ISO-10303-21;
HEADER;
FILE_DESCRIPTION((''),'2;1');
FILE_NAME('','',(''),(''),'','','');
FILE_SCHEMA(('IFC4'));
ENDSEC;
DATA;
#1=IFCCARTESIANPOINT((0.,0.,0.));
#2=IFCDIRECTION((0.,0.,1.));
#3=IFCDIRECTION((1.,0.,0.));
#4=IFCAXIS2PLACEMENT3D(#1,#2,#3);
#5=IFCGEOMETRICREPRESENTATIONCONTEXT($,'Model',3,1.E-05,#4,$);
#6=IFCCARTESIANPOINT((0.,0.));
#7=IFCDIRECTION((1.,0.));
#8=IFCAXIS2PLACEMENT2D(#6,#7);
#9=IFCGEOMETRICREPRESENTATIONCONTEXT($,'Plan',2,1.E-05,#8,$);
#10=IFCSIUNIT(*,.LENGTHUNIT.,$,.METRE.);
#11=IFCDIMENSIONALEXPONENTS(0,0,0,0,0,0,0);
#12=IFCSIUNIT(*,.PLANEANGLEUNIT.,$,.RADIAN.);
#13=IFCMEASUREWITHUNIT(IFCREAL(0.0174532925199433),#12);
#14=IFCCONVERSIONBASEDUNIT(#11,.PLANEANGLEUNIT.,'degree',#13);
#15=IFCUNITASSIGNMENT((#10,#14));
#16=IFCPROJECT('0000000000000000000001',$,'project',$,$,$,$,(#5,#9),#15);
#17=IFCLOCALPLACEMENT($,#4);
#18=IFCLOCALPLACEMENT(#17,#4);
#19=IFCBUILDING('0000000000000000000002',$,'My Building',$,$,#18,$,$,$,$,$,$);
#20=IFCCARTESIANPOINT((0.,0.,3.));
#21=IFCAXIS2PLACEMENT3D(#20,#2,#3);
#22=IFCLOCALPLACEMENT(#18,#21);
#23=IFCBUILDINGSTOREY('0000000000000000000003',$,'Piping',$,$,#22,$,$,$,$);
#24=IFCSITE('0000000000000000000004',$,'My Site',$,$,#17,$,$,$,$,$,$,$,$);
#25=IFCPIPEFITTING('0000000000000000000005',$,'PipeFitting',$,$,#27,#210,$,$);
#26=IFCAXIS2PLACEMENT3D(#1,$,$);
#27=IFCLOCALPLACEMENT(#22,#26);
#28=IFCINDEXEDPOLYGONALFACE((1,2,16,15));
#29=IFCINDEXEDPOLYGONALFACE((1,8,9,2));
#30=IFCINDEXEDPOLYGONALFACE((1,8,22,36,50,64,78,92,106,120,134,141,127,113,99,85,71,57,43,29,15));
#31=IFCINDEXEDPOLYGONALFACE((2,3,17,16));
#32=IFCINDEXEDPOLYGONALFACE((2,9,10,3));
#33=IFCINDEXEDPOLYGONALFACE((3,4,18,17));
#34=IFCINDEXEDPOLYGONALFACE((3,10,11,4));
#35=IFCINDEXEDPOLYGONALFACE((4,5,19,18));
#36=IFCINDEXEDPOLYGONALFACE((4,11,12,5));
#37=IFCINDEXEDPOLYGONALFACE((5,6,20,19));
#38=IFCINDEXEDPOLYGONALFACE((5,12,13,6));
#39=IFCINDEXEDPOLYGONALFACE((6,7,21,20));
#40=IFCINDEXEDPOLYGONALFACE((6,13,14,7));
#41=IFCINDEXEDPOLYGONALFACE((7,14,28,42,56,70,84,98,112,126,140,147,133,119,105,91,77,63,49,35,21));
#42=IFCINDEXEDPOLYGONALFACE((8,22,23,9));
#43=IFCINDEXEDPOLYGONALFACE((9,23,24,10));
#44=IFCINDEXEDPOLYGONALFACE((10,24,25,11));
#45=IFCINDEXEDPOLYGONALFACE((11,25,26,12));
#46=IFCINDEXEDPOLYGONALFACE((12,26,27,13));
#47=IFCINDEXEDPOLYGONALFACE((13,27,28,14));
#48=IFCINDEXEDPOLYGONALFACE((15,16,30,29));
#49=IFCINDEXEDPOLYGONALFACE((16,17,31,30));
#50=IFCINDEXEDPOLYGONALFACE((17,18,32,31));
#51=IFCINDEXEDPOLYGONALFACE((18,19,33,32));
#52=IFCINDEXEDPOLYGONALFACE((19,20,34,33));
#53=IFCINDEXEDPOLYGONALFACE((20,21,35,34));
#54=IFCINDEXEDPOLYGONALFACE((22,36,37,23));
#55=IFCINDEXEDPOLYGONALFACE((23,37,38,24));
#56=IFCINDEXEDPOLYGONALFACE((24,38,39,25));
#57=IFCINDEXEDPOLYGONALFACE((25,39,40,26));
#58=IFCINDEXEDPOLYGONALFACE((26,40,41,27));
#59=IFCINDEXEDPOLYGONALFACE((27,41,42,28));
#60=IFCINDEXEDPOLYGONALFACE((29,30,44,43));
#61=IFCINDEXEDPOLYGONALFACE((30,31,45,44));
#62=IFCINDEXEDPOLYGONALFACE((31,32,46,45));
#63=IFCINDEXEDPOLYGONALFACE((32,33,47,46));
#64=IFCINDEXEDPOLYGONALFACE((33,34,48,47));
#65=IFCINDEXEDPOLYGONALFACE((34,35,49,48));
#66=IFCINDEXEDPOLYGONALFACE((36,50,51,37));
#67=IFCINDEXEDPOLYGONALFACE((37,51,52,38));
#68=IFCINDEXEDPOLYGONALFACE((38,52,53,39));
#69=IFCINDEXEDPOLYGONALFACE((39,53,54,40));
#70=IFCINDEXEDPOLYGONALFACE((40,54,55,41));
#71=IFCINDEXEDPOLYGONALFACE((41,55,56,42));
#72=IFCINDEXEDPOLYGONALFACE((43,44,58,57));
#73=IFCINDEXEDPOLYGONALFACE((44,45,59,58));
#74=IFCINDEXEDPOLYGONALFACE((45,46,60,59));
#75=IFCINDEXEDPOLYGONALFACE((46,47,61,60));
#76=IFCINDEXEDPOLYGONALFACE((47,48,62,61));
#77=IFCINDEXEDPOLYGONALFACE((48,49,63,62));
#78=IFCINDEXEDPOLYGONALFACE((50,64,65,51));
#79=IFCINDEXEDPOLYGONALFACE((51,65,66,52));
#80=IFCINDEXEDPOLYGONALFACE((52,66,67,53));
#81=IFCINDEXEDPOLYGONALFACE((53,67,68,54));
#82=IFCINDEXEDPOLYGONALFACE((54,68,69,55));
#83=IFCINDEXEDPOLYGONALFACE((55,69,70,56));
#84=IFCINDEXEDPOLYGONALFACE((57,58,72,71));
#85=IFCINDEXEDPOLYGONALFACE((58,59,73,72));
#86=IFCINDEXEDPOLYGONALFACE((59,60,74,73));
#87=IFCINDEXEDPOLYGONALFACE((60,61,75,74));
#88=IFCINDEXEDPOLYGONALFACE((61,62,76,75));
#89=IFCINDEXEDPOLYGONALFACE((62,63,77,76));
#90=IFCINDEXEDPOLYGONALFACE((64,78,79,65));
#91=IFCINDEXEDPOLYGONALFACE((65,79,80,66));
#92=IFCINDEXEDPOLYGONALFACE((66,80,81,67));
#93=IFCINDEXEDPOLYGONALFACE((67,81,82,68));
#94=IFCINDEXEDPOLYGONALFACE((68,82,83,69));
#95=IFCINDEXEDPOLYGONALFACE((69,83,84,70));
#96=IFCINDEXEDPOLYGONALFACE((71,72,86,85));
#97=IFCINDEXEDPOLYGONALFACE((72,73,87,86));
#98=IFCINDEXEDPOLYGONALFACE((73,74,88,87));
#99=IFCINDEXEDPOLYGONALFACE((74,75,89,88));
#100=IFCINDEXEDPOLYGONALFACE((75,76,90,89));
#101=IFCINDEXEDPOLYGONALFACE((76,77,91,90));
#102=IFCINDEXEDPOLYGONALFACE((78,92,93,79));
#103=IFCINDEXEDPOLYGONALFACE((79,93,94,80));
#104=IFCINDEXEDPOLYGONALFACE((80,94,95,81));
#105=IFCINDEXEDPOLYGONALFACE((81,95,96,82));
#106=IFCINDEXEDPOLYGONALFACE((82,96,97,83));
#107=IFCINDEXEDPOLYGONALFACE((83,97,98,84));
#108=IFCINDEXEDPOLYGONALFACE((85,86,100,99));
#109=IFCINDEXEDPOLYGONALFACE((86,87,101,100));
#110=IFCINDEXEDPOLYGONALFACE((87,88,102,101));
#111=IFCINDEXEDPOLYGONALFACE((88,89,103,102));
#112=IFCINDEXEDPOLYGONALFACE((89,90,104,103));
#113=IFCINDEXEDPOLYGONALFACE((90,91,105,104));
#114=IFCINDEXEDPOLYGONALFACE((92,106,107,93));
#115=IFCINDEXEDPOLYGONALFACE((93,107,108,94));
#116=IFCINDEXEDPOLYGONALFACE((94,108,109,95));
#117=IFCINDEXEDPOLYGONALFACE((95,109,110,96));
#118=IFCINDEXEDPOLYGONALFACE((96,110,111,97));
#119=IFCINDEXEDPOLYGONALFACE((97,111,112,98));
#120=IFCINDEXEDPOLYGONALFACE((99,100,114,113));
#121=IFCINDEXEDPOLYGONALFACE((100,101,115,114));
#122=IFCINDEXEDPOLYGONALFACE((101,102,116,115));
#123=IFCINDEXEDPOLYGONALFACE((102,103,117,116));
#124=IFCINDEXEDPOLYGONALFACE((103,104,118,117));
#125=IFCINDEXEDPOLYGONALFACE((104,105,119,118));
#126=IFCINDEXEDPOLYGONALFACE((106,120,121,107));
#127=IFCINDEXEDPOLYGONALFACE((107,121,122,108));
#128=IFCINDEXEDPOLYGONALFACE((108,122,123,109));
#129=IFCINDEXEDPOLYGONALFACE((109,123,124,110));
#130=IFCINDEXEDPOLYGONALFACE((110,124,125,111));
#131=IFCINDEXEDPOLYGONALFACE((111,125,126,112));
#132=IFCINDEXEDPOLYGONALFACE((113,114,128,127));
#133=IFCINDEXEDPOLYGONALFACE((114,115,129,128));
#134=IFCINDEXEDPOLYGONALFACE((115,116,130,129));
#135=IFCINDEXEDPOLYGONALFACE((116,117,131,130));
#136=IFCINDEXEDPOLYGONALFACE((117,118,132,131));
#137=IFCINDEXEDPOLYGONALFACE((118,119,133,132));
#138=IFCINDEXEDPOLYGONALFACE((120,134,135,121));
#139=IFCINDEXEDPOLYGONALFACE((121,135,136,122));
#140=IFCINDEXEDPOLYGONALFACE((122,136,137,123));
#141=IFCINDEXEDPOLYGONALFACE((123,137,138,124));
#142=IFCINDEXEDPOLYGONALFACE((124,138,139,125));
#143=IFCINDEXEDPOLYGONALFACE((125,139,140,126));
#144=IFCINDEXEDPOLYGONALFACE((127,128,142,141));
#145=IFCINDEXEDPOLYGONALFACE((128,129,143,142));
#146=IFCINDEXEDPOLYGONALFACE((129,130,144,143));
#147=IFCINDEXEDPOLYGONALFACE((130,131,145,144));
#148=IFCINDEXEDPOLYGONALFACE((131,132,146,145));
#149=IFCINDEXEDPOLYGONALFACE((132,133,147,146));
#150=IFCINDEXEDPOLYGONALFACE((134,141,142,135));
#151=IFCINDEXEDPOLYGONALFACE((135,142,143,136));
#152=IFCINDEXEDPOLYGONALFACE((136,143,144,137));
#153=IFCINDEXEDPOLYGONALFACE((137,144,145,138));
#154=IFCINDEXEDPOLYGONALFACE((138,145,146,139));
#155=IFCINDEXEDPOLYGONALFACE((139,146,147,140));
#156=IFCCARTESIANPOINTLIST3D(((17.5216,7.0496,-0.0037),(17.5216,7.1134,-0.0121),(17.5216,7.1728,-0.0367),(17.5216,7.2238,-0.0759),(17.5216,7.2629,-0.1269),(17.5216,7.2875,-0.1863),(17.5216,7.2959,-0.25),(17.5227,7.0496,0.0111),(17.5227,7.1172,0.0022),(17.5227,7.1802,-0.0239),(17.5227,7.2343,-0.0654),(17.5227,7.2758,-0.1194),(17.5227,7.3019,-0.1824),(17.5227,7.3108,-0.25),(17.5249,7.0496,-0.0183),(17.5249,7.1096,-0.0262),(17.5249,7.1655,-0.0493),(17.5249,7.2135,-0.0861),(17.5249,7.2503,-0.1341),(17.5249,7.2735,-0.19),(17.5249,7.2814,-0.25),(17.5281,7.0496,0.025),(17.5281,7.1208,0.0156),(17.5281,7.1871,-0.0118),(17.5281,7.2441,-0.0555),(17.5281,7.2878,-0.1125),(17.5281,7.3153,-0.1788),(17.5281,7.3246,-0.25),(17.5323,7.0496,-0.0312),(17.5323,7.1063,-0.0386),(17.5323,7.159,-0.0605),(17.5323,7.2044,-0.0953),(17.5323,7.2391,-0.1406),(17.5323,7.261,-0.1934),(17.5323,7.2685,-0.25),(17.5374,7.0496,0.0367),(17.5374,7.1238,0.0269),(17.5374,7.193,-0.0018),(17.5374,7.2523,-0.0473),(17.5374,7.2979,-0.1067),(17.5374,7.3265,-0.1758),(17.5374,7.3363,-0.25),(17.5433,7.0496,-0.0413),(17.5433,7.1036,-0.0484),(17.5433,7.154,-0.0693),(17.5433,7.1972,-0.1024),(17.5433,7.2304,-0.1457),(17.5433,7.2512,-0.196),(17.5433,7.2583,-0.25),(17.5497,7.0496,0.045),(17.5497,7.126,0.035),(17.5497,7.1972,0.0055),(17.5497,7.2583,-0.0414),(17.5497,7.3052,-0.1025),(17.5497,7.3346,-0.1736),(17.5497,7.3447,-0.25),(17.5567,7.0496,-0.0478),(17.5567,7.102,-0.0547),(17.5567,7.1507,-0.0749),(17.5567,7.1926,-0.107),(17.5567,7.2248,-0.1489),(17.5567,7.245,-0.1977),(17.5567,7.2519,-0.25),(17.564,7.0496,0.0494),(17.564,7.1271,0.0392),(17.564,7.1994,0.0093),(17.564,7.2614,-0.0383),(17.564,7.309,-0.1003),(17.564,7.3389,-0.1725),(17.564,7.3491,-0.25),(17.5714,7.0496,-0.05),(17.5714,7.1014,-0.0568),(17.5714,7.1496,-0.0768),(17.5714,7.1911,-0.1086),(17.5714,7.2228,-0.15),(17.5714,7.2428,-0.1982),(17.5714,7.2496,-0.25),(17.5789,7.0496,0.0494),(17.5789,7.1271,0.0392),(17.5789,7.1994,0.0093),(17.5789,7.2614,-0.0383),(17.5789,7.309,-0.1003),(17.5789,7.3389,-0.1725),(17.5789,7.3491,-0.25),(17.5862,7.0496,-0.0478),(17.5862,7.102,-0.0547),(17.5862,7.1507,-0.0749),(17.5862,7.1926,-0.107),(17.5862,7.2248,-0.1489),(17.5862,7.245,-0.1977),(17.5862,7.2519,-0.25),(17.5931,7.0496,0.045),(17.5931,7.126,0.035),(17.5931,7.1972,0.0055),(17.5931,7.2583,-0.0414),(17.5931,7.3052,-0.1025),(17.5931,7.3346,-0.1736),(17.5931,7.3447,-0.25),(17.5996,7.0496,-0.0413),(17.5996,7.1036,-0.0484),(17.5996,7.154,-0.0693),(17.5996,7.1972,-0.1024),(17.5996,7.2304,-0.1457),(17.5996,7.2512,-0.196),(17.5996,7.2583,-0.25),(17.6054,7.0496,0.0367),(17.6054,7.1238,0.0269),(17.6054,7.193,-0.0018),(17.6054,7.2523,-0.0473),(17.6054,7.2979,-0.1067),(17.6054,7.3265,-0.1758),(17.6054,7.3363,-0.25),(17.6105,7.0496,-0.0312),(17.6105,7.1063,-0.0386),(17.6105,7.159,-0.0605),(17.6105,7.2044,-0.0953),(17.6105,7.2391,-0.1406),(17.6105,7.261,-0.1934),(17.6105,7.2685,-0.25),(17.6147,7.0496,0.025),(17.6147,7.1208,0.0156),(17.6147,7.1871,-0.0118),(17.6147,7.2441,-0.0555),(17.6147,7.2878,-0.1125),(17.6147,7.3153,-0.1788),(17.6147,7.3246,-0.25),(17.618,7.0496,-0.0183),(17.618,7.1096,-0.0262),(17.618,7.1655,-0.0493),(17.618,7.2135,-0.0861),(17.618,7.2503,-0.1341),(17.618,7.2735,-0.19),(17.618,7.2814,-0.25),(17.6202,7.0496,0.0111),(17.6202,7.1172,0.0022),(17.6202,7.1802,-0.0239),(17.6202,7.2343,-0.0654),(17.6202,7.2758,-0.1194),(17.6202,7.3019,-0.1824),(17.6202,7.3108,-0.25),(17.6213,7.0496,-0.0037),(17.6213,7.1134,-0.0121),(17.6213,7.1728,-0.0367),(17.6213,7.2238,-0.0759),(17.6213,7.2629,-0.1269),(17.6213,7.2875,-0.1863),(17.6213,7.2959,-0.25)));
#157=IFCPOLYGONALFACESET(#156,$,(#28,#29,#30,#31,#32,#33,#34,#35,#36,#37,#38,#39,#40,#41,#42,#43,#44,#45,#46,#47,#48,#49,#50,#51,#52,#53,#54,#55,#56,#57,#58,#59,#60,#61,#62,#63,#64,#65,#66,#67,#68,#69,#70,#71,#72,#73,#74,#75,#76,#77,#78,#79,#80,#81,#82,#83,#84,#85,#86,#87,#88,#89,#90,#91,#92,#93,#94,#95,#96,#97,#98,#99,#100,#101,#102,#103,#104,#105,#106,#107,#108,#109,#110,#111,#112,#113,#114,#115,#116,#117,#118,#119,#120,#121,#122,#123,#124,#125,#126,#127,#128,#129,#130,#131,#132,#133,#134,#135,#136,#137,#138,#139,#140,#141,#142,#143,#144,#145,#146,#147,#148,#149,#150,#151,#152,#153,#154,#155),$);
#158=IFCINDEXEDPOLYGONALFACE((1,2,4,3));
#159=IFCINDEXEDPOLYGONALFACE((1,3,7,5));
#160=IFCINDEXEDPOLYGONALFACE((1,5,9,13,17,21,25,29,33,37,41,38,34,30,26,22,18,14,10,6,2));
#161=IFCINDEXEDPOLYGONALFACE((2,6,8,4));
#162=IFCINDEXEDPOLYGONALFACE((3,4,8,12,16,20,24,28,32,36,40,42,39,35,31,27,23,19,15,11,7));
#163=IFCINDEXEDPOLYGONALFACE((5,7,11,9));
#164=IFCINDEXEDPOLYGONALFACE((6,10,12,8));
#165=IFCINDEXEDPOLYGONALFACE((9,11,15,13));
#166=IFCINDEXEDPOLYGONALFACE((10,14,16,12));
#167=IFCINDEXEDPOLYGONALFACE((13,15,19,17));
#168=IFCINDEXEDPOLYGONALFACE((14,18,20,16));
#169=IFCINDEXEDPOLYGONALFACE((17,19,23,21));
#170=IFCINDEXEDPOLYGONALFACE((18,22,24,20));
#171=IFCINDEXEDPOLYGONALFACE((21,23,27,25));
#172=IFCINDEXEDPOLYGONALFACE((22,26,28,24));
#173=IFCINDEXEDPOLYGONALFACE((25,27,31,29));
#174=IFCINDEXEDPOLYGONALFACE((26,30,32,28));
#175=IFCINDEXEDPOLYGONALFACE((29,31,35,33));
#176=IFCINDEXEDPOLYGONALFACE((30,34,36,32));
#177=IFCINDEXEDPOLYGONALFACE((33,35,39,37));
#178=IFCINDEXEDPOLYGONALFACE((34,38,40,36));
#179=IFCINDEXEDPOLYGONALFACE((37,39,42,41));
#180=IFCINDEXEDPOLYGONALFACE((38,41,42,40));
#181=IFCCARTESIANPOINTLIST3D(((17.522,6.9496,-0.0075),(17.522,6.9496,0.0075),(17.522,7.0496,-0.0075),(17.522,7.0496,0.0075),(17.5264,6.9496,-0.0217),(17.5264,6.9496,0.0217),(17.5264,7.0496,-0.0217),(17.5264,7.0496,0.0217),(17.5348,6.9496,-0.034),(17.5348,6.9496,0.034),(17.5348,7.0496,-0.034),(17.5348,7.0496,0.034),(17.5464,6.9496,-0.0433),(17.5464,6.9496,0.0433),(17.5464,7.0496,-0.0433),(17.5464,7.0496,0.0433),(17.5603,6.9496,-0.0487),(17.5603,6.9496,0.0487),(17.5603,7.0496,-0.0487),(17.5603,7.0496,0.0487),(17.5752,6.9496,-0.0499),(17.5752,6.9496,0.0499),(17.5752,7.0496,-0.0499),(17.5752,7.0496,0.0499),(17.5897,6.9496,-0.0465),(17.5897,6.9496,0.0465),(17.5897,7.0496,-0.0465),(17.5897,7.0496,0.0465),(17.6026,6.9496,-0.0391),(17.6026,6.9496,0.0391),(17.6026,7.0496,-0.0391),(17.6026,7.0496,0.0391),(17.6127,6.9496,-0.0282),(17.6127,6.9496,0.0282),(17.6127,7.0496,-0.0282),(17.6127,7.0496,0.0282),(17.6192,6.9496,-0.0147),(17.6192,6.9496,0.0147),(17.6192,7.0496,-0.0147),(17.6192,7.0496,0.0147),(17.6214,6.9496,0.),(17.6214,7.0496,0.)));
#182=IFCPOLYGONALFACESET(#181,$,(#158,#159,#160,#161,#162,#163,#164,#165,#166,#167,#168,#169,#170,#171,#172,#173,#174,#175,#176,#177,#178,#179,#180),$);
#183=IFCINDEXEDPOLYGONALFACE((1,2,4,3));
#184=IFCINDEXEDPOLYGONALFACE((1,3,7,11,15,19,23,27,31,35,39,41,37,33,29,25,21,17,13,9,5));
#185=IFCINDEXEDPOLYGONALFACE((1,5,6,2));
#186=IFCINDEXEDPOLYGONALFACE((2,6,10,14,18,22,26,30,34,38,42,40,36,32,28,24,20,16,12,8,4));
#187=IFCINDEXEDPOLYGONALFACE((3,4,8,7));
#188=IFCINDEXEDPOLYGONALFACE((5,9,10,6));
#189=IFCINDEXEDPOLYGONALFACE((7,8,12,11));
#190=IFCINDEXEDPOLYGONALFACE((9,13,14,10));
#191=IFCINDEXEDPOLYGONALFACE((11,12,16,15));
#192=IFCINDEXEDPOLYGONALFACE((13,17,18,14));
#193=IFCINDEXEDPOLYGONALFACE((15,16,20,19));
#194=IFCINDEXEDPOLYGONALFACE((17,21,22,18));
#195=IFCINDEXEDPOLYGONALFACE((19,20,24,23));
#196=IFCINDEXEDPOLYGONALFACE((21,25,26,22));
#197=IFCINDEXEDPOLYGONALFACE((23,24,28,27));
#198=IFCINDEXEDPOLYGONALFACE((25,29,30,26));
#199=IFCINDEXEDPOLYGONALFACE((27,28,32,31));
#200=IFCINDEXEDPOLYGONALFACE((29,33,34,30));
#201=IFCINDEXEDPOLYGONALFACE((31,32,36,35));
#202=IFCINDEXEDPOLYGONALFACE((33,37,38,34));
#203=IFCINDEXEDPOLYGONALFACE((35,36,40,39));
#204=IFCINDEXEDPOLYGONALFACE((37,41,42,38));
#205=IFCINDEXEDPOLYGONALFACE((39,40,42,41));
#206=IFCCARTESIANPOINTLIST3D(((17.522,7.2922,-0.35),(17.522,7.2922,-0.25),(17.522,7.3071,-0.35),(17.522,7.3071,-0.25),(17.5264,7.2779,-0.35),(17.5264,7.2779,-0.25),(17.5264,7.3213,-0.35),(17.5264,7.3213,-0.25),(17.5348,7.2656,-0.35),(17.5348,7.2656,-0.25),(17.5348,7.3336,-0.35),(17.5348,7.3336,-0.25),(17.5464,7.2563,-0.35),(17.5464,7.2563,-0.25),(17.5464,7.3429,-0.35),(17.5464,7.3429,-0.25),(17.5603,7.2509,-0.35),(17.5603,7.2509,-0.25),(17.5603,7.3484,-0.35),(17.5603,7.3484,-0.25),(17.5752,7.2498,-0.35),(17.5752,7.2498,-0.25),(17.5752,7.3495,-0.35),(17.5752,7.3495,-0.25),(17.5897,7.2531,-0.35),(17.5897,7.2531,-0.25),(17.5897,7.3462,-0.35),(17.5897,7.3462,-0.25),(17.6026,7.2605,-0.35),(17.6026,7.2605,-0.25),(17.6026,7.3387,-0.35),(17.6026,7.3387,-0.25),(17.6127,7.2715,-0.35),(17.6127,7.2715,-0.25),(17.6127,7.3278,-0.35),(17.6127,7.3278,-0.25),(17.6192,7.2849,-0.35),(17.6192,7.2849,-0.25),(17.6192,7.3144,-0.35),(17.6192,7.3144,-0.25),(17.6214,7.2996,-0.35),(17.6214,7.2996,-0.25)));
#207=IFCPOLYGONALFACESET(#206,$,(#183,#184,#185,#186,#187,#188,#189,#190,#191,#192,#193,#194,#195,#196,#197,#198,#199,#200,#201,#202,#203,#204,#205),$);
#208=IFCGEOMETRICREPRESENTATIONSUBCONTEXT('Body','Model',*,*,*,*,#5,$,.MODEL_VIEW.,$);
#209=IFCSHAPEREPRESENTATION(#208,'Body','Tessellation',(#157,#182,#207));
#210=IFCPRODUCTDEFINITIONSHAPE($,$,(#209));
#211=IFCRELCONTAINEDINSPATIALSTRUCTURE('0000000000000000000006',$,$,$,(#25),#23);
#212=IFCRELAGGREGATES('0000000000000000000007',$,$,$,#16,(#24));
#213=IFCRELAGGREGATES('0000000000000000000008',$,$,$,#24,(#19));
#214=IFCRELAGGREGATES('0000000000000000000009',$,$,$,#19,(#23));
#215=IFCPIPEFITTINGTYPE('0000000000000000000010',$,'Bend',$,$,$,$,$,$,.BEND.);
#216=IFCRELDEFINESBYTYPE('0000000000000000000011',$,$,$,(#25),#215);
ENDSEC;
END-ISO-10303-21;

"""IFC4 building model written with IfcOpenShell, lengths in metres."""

from ifc_helpers import new_model, entity, si_unit, converted_unit, frame, origin_with_axes, origin_2d_with_axis, place, context, subcontext, project, spatial, circle, extrude, source, transform, mapped, type_object, type_shapes, element, save


model = new_model("IFC4")

# Units and contexts
model_context = context("Model", 3, precision=1e-05, world=origin_with_axes())
plan_context = context("Plan", 2, precision=1e-05, world=origin_2d_with_axis())
body_context = subcontext(model_context, "Body", "Model", "MODEL_VIEW")
ifc_project = project(units=[si_unit("LENGTHUNIT", "METRE"), converted_unit("PLANEANGLEUNIT", "degree", entity("IfcReal", 0.0174532925199433), si_unit("PLANEANGLEUNIT", "RADIAN"), dimensions=[0, 0, 0, 0, 0, 0, 0])], contexts=[model_context, plan_context])

# Site, building, storey
site_placement = place(None, origin_with_axes())
site = spatial("IfcSite", under=ifc_project, at=site_placement, Name="My Site")
building_placement = place(site_placement, origin_with_axes())
building = spatial("IfcBuilding", under=site, at=building_placement, Name="My Building")
storey_placement = place(building_placement, frame((0.0, 0.0, 3.0), z_axis=(0.0, 0.0, 1.0), x_axis=(1.0, 0.0, 0.0)))
storey = spatial("IfcBuildingStorey", under=building, at=storey_placement, Name="Piping")

# Pipe fitting
pipe_fitting_type = type_object("IfcPipeFittingType", Name="Bend", PredefinedType="BEND")
shared_shape = source(origin_with_axes(), body_context, "Body", "SolidModel", [
    entity("IfcSweptDiskSolid", entity("IfcIndexedPolyCurve", entity("IfcCartesianPointList3D", [[0.0, 0.0, -0.1], [0.0, -0.0732, -0.2768], [0.0, -0.25, -0.35]]), [entity("IfcArcIndex", [1, 2, 3])]), 0.05),
    extrude(circle(Radius=0.05), origin_with_axes(), (0.0, 0.0, -1.0), 0.1),
    extrude(circle(Radius=0.05), frame((0.0, -0.25, -0.35), z_axis=(0.0, -1.0, 0.0), x_axis=(1.0, 0.0, 0.0)), (0.0, 0.0, 1.0), 0.1),
])
type_shapes(pipe_fitting_type, [shared_shape])
for number, where, z_axis, x_axis, name in (
    (1, (17.5714, 6.9496, 0.0), (0.0, -1.0, 0.0), (1.0, 0.0, 0.0), "PipeFitting"),
):
    element("IfcPipeFitting", number, at=place(storey_placement, frame(where, z_axis=z_axis, x_axis=x_axis)), inside=storey, type_object=pipe_fitting_type, Name=name, context=body_context, shape_type="MappedRepresentation", body=[
        mapped(shared_shape, transform((0.0, 0.0, 0.0), x_axis=(1.0, 0.0, 0.0), y_axis=(0.0, 1.0, 0.0), z_axis=(0.0, 0.0, 1.0), scale=1.0)),
    ])

save(model, "model.ifc")
